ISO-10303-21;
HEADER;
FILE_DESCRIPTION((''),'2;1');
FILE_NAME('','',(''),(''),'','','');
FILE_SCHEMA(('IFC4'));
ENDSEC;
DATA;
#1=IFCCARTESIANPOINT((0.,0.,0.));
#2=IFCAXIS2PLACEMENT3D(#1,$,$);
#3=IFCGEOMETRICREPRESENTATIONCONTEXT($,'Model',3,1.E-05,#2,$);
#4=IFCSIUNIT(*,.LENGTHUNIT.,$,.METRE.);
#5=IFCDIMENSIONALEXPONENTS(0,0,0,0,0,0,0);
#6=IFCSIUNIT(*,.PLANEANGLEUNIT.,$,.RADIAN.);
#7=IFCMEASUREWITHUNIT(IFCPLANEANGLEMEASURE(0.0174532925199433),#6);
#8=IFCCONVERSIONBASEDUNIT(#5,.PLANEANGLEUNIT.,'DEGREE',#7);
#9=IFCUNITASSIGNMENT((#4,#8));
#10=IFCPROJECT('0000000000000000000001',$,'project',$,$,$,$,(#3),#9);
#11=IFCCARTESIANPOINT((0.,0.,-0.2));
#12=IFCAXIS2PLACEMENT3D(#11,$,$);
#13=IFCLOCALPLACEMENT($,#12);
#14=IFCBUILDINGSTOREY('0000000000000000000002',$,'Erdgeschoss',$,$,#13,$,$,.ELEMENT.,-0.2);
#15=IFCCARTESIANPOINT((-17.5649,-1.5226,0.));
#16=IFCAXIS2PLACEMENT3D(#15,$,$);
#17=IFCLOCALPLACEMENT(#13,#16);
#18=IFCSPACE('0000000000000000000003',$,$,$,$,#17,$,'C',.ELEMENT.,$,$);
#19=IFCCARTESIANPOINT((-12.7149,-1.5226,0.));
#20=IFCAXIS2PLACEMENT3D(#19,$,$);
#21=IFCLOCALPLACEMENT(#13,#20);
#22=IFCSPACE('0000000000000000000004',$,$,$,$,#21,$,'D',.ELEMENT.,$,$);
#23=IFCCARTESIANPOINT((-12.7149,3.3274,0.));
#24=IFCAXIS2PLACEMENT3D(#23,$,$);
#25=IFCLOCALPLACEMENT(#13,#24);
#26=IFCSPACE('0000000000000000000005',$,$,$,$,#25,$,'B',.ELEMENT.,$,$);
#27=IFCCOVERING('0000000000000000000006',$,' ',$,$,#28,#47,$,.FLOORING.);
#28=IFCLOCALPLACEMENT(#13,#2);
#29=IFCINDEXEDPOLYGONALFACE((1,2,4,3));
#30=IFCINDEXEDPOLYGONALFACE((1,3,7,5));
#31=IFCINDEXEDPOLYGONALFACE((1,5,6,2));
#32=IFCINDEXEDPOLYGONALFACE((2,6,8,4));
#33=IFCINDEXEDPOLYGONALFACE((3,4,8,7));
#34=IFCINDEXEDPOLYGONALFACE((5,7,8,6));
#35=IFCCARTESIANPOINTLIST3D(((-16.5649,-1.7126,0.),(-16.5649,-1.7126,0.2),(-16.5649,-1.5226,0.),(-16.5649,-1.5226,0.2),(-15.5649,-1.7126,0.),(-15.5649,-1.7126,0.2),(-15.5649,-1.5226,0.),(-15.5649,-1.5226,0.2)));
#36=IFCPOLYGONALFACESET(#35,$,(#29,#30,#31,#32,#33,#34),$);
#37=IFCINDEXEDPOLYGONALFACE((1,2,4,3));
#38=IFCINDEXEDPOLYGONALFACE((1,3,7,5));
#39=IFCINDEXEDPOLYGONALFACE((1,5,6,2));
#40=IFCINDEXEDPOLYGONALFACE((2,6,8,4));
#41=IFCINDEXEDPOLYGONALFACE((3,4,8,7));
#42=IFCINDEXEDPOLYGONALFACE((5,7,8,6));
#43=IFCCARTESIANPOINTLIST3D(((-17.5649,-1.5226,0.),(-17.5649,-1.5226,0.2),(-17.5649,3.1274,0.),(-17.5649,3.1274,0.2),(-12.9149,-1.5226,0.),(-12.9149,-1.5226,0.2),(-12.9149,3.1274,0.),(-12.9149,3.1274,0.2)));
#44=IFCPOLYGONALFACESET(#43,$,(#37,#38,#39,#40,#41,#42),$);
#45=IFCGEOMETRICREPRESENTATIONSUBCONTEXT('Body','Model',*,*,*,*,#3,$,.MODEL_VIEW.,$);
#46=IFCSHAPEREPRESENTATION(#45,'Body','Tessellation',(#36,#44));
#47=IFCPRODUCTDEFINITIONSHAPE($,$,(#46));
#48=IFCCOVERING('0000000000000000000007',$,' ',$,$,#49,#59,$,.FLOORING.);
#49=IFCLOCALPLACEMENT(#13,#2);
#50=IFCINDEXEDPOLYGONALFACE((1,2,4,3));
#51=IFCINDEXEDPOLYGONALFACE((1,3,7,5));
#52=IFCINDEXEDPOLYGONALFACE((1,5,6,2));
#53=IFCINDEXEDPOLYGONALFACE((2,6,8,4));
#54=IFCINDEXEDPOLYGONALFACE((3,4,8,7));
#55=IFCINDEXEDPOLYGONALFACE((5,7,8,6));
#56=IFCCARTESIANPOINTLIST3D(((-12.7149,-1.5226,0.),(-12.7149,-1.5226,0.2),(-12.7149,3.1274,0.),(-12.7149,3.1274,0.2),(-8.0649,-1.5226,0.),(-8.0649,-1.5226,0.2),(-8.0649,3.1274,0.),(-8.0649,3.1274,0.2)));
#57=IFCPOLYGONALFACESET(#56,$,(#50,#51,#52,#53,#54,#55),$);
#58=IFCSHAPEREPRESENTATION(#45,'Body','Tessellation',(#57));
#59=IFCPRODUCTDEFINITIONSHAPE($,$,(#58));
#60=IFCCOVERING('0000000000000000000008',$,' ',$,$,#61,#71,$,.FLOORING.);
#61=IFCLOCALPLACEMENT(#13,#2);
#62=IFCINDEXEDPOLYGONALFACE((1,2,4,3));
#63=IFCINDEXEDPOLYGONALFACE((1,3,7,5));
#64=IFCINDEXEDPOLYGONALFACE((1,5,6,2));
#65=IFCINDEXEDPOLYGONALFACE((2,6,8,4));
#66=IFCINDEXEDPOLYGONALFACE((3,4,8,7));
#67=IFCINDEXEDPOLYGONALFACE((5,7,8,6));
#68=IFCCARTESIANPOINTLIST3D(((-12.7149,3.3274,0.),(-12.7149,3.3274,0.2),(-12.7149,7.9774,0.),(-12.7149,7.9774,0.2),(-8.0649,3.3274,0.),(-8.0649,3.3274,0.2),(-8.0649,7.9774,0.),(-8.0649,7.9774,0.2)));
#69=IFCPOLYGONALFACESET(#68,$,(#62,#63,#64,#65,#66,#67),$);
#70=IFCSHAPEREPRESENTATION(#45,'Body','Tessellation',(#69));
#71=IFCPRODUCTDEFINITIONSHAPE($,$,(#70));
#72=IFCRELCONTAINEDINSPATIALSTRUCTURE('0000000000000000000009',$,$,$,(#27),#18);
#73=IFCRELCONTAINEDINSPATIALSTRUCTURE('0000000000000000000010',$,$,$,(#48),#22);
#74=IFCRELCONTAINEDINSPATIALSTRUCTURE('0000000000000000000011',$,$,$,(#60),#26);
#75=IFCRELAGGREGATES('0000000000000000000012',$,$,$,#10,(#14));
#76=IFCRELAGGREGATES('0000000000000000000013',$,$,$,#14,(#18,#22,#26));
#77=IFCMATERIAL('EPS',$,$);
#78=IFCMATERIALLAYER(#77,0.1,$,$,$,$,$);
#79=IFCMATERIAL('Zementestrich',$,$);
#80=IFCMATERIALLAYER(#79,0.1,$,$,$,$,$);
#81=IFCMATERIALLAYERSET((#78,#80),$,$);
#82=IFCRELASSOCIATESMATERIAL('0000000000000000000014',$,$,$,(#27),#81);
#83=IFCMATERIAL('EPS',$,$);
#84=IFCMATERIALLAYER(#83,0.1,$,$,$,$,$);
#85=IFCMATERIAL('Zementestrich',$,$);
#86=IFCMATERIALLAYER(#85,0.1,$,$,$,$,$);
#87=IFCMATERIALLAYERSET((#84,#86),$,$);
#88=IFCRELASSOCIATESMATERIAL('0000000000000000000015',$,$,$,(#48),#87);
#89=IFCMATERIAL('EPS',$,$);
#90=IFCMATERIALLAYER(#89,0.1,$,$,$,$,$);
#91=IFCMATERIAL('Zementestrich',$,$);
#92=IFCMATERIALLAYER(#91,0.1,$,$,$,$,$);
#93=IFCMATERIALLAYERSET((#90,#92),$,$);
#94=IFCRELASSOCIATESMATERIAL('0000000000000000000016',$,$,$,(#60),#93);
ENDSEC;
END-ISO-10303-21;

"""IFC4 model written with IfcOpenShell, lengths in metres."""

from ifc_helpers import new_model, entity, si_unit, converted_unit, frame, frame_2d, origin, origin_with_axes, place, context, subcontext, project, spatial, rectangle, extrude, material, layer, layer_set, layer_usage, element, save


model = new_model("IFC4")

# Units and contexts
model_context = context("Model", 3, precision=1e-05, world=origin())
body_context = subcontext(model_context, "Body", "Model", "MODEL_VIEW")
ifc_project = project(units=[si_unit("LENGTHUNIT", "METRE"), converted_unit("PLANEANGLEUNIT", "DEGREE", entity("IfcPlaneAngleMeasure", 0.0174532925199433), si_unit("PLANEANGLEUNIT", "RADIAN"), dimensions=[0, 0, 0, 0, 0, 0, 0])], contexts=[model_context])

# Storey
storey_placement = place(None, frame((0.0, 0.0, -0.2)))
storey = spatial("IfcBuildingStorey", under=ifc_project, at=storey_placement, Name="Erdgeschoss", CompositionType="ELEMENT", Elevation=-0.2)

# Shared definitions
space_1_placement = place(storey_placement, frame((-17.5649, -1.5226, 0.0)))
space_1 = spatial("IfcSpace", under=storey, at=space_1_placement, LongName="C", CompositionType="ELEMENT")

# Covering
ifc_material_1 = material(Name="EPS")
ifc_layer_1 = layer(ifc_material_1, 0.1)
ifc_material_2 = material(Name="Zementestrich")
ifc_layer_2 = layer(ifc_material_2, 0.1)
ifc_layer_set_1 = layer_set([ifc_layer_1, ifc_layer_2])
ifc_layer_usage_1 = layer_usage(ifc_layer_set_1, "AXIS3", "POSITIVE", 0.0)
covering_1_placement = place(space_1_placement, frame((0.0, -0.19, 0.0)))
element("IfcCovering", 1, at=covering_1_placement, inside=space_1, material=ifc_layer_usage_1, Name=" ", PredefinedType="FLOORING", context=body_context, shape_type="SweptSolid", body=[
    extrude(rectangle(XDim=0.19, YDim=1.0, at=frame_2d((0.5, -0.095), x_axis=(0.0, -1.0))), frame((1.0, 0.19, 0.0), z_axis=(0.0, 0.0, 1.0), x_axis=(1.0, 0.0, 0.0)), (0.0, 0.0, 1.0), 0.2),
    extrude(rectangle(XDim=4.65, YDim=4.65, at=frame_2d((2.325, -2.325), x_axis=(0.0, -1.0))), frame((0.0, 4.84, 0.0), z_axis=(0.0, 0.0, 1.0), x_axis=(1.0, 0.0, 0.0)), (0.0, 0.0, 1.0), 0.2),
])

# Shared definitions
space_2_placement = place(storey_placement, frame((-12.7149, -1.5226, 0.0)))
space_2 = spatial("IfcSpace", under=storey, at=space_2_placement, LongName="D", CompositionType="ELEMENT")

# Covering
ifc_material_3 = material(Name="EPS")
ifc_layer_3 = layer(ifc_material_3, 0.1)
ifc_material_4 = material(Name="Zementestrich")
ifc_layer_4 = layer(ifc_material_4, 0.1)
ifc_layer_set_2 = layer_set([ifc_layer_3, ifc_layer_4])
ifc_layer_usage_2 = layer_usage(ifc_layer_set_2, "AXIS3", "POSITIVE", 0.0)
covering_2_placement = place(space_2_placement, origin())
element("IfcCovering", 2, at=covering_2_placement, inside=space_2, material=ifc_layer_usage_2, Name=" ", PredefinedType="FLOORING", context=body_context, shape_type="SweptSolid", body=[
    extrude(rectangle(XDim=4.65, YDim=4.65, at=frame_2d((2.325, -2.325), x_axis=(0.0, -1.0))), frame((0.0, 4.65, 0.0), z_axis=(0.0, 0.0, 1.0), x_axis=(1.0, 0.0, 0.0)), (0.0, 0.0, 1.0), 0.2),
])

# Shared definitions
space_3_placement = place(storey_placement, frame((-12.7149, 3.3274, 0.0)))
space_3 = spatial("IfcSpace", under=storey, at=space_3_placement, LongName="B", CompositionType="ELEMENT")

# Covering
ifc_material_5 = material(Name="EPS")
ifc_layer_5 = layer(ifc_material_5, 0.1)
ifc_material_6 = material(Name="Zementestrich")
ifc_layer_6 = layer(ifc_material_6, 0.1)
ifc_layer_set_3 = layer_set([ifc_layer_5, ifc_layer_6])
ifc_layer_usage_3 = layer_usage(ifc_layer_set_3, "AXIS3", "POSITIVE", 0.0)
covering_3_placement = place(space_3_placement, origin())
element("IfcCovering", 3, at=covering_3_placement, inside=space_3, material=ifc_layer_usage_3, Name=" ", PredefinedType="FLOORING", context=body_context, shape_type="SweptSolid", body=[
    extrude(rectangle(XDim=4.65, YDim=4.65, at=frame_2d((2.325, 2.325), x_axis=(1.0, 0.0))), origin_with_axes(), (0.0, 0.0, 1.0), 0.2),
])

save(model, "model.ifc")
